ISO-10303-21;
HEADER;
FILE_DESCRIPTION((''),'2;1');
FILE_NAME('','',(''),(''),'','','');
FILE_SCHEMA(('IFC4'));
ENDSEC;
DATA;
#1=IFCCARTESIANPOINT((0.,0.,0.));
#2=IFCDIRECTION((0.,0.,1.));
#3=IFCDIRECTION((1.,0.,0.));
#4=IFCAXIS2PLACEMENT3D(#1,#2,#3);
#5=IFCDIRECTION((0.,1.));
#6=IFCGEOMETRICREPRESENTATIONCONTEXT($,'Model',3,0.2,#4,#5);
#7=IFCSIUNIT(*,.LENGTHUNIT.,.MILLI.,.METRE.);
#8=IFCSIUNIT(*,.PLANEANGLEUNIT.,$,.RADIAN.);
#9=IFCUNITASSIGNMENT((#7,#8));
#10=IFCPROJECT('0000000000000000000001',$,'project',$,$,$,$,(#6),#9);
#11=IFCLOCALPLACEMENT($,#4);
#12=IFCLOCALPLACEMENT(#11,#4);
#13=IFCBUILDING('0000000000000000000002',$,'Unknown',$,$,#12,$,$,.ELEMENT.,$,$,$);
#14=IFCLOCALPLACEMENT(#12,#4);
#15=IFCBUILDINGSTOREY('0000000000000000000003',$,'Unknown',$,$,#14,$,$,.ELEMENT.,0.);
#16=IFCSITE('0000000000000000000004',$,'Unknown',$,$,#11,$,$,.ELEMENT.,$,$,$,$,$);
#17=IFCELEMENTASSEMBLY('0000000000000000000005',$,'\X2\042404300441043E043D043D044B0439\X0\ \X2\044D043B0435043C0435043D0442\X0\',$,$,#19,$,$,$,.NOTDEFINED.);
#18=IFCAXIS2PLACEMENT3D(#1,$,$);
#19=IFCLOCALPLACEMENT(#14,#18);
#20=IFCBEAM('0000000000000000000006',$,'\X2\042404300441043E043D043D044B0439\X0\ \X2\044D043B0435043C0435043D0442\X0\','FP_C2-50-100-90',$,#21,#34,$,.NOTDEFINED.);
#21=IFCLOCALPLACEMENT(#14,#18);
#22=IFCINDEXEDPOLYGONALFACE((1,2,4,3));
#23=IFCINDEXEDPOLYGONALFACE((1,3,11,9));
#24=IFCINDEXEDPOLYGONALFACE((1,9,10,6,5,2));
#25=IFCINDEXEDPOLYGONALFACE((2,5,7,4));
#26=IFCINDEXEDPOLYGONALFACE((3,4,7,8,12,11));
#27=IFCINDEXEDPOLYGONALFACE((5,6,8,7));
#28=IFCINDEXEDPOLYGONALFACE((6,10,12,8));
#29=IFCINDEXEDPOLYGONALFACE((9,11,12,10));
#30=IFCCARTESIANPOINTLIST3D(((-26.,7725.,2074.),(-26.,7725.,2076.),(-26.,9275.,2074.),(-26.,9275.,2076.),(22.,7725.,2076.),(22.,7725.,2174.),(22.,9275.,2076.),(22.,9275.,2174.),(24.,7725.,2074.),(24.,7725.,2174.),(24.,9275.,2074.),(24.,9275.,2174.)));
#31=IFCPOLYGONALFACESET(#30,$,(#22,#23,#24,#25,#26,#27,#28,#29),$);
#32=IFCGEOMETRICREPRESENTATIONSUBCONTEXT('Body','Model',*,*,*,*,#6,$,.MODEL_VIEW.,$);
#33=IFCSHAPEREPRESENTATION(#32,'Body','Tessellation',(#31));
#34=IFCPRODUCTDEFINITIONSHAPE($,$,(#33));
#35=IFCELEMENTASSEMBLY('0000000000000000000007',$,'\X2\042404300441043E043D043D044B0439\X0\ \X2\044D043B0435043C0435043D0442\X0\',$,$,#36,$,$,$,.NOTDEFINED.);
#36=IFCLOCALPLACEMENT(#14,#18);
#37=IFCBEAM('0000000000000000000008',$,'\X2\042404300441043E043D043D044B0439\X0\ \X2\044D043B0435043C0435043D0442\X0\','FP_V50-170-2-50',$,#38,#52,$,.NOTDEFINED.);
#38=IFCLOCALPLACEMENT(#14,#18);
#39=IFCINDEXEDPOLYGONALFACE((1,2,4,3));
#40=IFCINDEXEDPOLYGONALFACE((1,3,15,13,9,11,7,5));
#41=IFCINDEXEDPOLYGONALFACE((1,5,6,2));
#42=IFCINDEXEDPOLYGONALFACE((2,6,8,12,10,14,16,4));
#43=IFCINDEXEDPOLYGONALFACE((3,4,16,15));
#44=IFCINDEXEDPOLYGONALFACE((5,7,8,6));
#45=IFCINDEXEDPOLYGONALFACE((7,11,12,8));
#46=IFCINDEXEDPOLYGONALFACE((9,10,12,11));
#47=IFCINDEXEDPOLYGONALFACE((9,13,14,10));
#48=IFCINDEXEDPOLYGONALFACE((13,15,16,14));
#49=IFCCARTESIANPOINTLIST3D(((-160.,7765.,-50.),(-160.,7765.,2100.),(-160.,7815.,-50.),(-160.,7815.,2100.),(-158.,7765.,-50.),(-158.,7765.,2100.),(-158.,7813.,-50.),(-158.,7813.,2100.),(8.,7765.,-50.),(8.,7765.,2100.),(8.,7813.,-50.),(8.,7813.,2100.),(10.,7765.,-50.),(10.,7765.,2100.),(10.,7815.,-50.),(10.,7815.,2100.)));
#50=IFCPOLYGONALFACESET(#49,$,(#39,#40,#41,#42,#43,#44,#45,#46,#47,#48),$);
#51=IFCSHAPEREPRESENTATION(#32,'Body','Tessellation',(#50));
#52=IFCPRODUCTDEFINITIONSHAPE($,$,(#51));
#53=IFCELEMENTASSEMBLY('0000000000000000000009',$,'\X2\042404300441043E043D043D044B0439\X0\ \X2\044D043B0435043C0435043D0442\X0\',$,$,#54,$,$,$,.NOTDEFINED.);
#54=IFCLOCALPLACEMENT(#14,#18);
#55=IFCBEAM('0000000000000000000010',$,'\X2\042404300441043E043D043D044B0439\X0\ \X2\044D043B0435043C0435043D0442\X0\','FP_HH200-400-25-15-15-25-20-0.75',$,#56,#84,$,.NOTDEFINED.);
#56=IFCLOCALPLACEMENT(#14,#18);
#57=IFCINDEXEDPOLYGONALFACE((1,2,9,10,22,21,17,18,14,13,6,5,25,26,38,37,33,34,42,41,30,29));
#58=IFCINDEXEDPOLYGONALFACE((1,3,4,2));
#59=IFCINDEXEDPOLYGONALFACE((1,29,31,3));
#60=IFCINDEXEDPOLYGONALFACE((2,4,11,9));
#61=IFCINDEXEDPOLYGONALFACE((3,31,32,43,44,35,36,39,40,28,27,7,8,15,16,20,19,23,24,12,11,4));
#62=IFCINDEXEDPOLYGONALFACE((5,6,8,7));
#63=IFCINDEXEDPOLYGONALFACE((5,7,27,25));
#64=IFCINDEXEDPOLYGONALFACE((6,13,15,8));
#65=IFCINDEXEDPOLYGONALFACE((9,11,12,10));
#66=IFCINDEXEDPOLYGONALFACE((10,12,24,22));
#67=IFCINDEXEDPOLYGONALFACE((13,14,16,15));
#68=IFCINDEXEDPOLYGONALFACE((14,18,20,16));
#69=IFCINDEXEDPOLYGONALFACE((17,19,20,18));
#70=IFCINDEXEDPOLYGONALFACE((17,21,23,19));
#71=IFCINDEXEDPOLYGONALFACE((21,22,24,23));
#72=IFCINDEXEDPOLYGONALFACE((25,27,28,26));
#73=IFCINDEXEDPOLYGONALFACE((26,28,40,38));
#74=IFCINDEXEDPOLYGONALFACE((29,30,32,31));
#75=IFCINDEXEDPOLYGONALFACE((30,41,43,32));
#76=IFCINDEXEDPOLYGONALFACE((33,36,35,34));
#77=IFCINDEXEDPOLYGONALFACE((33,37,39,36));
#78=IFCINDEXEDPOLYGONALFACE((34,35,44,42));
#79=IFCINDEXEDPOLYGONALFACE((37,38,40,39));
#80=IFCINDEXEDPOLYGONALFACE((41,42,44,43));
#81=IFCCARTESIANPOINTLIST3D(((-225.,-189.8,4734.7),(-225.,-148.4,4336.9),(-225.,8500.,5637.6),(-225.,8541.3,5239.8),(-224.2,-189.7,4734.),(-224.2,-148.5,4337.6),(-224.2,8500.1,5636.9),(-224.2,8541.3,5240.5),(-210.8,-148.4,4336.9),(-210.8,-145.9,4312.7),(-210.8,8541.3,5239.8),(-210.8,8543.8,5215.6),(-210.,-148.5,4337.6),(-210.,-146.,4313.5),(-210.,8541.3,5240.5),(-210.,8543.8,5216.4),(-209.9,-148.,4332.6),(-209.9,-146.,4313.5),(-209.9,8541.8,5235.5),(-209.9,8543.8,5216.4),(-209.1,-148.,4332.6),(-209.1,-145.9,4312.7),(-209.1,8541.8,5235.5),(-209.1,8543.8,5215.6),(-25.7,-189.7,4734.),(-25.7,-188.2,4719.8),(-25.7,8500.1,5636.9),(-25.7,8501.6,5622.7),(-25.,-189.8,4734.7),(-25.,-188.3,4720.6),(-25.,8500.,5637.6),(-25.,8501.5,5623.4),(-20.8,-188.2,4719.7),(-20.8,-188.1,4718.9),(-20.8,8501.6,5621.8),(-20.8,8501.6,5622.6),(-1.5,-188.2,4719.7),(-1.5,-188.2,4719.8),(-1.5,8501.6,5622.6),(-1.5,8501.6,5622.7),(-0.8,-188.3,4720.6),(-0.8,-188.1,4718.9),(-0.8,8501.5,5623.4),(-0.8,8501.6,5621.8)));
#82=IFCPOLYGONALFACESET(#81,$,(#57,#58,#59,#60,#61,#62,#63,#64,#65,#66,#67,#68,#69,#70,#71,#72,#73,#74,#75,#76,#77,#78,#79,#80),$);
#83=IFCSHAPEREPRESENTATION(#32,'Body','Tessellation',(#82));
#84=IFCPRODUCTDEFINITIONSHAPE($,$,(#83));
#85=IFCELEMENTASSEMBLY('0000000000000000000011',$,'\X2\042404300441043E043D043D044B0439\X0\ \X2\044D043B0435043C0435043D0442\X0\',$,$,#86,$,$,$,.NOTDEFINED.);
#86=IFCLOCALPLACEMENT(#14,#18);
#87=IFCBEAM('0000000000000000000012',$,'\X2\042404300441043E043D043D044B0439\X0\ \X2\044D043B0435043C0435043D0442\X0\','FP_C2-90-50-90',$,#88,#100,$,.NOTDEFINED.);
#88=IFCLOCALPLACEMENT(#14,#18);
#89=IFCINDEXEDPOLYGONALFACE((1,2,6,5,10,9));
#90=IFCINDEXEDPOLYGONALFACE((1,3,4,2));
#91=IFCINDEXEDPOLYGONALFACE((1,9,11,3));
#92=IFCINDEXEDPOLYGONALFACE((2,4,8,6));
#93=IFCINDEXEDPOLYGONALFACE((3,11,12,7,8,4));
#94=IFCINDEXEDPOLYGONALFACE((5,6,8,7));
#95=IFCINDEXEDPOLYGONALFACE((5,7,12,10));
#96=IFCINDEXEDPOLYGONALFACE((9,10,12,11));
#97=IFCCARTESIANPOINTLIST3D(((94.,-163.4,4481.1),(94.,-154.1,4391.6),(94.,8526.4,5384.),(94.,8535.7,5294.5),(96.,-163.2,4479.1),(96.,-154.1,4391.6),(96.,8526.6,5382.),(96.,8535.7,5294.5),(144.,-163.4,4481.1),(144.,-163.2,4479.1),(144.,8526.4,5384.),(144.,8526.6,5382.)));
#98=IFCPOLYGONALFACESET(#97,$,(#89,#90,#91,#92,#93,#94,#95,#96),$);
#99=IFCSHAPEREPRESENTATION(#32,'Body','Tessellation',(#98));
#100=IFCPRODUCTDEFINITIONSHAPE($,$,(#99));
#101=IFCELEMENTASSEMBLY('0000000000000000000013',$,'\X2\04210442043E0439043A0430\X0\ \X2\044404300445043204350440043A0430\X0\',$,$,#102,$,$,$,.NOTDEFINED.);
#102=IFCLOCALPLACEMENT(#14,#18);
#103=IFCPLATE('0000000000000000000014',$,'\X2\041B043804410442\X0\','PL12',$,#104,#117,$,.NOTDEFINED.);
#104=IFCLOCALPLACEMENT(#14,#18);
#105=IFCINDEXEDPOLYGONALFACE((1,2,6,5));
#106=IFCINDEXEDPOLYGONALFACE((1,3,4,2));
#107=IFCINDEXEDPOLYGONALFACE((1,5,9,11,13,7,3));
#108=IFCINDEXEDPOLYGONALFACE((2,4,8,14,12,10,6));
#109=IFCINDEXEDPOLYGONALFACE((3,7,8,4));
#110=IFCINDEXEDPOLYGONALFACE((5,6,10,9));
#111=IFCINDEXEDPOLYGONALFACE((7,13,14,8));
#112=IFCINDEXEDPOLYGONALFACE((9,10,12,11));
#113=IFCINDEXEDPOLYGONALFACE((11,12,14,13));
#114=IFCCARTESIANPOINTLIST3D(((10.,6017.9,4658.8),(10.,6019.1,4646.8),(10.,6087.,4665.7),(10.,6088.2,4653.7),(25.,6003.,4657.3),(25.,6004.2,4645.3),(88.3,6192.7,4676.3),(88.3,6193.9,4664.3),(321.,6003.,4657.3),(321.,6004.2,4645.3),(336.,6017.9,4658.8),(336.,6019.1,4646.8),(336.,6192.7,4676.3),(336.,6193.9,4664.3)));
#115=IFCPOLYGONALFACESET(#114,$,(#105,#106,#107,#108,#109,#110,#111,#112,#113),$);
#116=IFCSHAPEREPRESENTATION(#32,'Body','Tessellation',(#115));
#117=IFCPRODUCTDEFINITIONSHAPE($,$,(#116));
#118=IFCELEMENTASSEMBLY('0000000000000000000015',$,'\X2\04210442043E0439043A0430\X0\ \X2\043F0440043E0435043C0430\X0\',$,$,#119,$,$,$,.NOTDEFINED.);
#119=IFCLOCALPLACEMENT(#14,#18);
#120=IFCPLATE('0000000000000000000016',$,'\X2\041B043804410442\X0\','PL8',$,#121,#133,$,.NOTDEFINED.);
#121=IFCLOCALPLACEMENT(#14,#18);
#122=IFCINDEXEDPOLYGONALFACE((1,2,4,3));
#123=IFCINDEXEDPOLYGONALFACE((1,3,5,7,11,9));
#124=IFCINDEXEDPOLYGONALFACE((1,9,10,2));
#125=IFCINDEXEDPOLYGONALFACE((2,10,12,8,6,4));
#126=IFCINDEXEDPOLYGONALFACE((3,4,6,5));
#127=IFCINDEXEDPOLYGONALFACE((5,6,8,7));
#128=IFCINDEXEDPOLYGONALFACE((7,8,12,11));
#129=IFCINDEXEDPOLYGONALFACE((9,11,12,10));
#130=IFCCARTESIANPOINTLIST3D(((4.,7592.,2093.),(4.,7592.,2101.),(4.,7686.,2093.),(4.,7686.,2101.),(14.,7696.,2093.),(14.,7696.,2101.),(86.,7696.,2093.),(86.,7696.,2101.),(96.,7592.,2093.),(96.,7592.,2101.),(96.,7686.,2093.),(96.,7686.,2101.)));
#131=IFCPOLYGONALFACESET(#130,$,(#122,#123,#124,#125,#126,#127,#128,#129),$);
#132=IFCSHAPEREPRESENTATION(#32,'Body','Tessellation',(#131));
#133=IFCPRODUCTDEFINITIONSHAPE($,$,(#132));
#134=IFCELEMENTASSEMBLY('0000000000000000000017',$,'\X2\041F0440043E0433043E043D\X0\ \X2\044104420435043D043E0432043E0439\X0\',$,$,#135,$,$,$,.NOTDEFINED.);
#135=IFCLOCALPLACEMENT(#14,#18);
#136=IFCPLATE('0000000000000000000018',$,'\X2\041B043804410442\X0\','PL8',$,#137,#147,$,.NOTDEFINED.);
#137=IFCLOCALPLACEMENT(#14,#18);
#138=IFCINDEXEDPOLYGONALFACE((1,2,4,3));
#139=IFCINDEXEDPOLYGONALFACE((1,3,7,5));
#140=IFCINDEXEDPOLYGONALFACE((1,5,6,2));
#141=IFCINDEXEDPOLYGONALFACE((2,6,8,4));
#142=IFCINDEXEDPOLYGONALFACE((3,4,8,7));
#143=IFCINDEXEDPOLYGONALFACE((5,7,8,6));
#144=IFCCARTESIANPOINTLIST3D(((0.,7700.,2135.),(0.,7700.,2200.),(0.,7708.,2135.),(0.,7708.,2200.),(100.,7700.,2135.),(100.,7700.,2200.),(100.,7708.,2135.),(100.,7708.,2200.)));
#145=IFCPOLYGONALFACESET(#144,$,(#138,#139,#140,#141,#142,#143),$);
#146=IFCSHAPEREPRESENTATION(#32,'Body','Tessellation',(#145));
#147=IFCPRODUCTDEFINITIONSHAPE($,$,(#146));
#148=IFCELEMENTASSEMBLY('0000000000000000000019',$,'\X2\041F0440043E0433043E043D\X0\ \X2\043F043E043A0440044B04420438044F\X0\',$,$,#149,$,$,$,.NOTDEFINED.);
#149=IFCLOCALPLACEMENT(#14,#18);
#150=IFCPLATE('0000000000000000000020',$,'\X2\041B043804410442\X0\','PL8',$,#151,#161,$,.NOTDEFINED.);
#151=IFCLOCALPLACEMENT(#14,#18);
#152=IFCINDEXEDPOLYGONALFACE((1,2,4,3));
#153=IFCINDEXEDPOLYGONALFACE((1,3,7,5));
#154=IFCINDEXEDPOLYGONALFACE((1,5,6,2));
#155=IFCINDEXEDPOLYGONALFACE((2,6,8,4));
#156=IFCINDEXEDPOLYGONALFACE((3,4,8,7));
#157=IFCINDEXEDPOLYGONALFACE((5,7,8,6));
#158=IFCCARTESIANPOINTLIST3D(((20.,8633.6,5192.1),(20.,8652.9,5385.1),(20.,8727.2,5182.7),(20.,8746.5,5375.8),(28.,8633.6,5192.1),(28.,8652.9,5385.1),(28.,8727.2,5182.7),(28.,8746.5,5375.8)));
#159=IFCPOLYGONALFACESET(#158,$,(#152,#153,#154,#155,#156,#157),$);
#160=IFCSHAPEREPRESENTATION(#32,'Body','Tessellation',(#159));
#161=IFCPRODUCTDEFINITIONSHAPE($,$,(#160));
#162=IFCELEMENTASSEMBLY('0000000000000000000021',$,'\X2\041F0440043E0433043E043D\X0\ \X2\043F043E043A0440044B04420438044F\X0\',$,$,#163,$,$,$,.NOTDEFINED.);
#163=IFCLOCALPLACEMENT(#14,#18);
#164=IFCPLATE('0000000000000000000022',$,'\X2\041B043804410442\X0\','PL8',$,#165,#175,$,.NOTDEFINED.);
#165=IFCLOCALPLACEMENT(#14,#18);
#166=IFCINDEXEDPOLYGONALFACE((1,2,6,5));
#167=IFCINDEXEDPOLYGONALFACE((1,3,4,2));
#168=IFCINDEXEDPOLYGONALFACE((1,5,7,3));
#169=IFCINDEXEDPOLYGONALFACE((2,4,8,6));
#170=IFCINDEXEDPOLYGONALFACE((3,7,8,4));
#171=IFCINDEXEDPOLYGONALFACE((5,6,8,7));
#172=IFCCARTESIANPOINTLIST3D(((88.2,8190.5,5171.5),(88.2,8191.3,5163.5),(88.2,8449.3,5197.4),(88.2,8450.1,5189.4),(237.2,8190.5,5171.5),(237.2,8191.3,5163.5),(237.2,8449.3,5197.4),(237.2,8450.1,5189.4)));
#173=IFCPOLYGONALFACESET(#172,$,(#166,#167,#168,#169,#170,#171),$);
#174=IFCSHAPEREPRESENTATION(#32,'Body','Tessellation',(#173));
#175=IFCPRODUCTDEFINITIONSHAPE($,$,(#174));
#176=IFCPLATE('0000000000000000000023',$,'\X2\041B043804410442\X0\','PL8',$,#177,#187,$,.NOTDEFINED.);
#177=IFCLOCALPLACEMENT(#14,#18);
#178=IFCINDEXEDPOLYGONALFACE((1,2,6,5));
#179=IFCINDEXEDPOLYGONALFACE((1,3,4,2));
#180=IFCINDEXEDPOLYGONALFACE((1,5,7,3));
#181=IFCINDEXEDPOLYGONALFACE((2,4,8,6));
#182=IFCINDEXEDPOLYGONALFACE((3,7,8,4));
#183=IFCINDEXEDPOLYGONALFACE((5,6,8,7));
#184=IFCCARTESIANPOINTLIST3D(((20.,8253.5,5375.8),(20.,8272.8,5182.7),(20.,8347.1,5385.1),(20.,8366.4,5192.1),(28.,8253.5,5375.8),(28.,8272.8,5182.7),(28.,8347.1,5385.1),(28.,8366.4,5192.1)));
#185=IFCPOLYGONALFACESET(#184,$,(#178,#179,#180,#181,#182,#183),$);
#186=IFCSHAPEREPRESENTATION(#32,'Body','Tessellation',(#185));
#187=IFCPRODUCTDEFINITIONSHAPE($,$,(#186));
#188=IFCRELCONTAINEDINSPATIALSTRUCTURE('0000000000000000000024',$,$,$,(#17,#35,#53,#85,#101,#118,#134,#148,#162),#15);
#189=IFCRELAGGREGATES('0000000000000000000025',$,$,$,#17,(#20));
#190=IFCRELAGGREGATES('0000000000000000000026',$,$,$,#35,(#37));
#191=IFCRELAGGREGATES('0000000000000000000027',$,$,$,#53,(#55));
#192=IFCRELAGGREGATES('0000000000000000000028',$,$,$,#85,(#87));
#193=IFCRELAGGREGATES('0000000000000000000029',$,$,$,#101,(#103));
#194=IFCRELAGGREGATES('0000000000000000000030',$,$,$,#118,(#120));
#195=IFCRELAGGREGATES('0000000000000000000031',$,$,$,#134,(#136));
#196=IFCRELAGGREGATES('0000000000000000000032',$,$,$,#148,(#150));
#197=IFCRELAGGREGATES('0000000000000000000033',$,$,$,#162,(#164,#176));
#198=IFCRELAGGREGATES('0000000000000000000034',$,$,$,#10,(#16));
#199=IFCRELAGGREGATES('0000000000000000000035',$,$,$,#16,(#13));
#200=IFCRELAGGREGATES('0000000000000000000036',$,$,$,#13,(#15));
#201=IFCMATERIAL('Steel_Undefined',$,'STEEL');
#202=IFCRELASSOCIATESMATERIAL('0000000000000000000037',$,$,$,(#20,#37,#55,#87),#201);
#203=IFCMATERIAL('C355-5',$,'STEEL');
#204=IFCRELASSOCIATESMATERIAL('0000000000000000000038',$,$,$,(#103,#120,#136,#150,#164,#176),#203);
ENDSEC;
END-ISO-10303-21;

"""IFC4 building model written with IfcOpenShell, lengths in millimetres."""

from ifc_helpers import new_model, si_unit, direction, frame, origin_with_axes, place, context, subcontext, project, spatial, line, indexed_curve, outline, extrude, material, element, aggregate, save


model = new_model("IFC4")

# Units and contexts
model_context = context("Model", 3, precision=0.2, world=origin_with_axes(), true_north=direction((0.0, 1.0)))
body_context = subcontext(model_context, "Body", "Model", "MODEL_VIEW")
ifc_project = project(units=[si_unit("LENGTHUNIT", "METRE", prefix="MILLI"), si_unit("PLANEANGLEUNIT", "RADIAN")], contexts=[model_context])

# Site, building, storey
site_placement = place(None, origin_with_axes())
site = spatial("IfcSite", under=ifc_project, at=site_placement, Name="Unknown", CompositionType="ELEMENT")
building_placement = place(site_placement, origin_with_axes())
building = spatial("IfcBuilding", under=site, at=building_placement, Name="Unknown", CompositionType="ELEMENT")
storey_placement = place(building_placement, origin_with_axes())
storey = spatial("IfcBuildingStorey", under=building, at=storey_placement, Name="Unknown", CompositionType="ELEMENT", Elevation=0.0)

# Element assemblies, beams
ifc_material_1 = material(Name="Steel_Undefined", Category="STEEL")
assembly_1_placement = place(storey_placement, frame((-1.0, 7725.0, 2075.0), z_axis=(1.0, 0.0, 0.0), x_axis=(0.0, 1.0, 0.0)))
assembly_1 = element("IfcElementAssembly", 1, at=assembly_1_placement, inside=storey, Name="Фасонный элемент", PredefinedType="NOTDEFINED")
beam_1_placement = place(assembly_1_placement, origin_with_axes())
beam_1 = element("IfcBeam", 2, at=beam_1_placement, material=ifc_material_1, Name="Фасонный элемент", Description="FP_C2-50-100-90", PredefinedType="NOTDEFINED", context=body_context, shape_type="SolidModel", body=[
    extrude(outline(indexed_curve([(-25.0, -1.0), (25.0, -1.0), (25.0, 99.0), (23.0, 99.0), (23.0, 1.0), (-25.0, 1.0)], segments=[line(1, 2, 3, 4, 5, 6, 1)])), frame((0.0, 0.0, 0.0), z_axis=(-1.0, 0.0, 0.0), x_axis=(0.0, 0.0, 1.0)), (0.0, 0.0, -1.0), 1550.0),
])
aggregate(assembly_1, [beam_1])
assembly_2_placement = place(storey_placement, frame((-75.0, 7790.0, 2100.0), z_axis=(1.0, 0.0, 0.0), x_axis=(0.0, 0.0, -1.0)))
assembly_2 = element("IfcElementAssembly", 3, at=assembly_2_placement, inside=storey, Name="Фасонный элемент", PredefinedType="NOTDEFINED")
beam_2_placement = place(assembly_2_placement, origin_with_axes())
beam_2 = element("IfcBeam", 4, at=beam_2_placement, material=ifc_material_1, Name="Фасонный элемент", Description="FP_V50-170-2-50", PredefinedType="NOTDEFINED", context=body_context, shape_type="SolidModel", body=[
    extrude(outline(indexed_curve([(-85.0, -25.0), (-83.0, -25.0), (-83.0, 23.0), (83.0, 23.0), (83.0, -25.0), (85.0, -25.0), (85.0, 25.0), (-85.0, 25.0)], segments=[line(1, 2, 3, 4, 5, 6, 7, 8, 1)])), frame((0.0, 0.0, 0.0), z_axis=(-1.0, 0.0, 0.0), x_axis=(0.0, 0.0, 1.0)), (0.0, 0.0, -1.0), 2150.0),
])
aggregate(assembly_2, [beam_2])
assembly_3_placement = place(storey_placement, frame((-125.0, 8520.7, 5438.7), z_axis=(0.0, -0.103345, 0.994646), x_axis=(0.0, -0.994646, -0.103345)))
assembly_3 = element("IfcElementAssembly", 5, at=assembly_3_placement, inside=storey, Name="Фасонный элемент", PredefinedType="NOTDEFINED")
beam_3_placement = place(assembly_3_placement, origin_with_axes())
beam_3 = element("IfcBeam", 6, at=beam_3_placement, material=ifc_material_1, Name="Фасонный элемент", Description="FP_HH200-400-25-15-15-25-20-0.75", PredefinedType="NOTDEFINED", context=body_context, shape_type="SolidModel", body=[
    extrude(outline(indexed_curve([(-200.0, -100.0), (200.0, -100.0), (200.0, 100.0), (185.8, 100.0), (185.8, 124.2), (184.1, 124.2), (184.1, 104.2), (184.9, 104.2), (184.9, 123.5), (185.0, 123.5), (185.0, 99.2), (199.2, 99.2), (199.2, -99.2), (-199.2, -99.2), (-199.2, -85.0), (-223.5, -85.0), (-223.5, -84.9), (-204.2, -84.9), (-204.2, -84.1), (-224.2, -84.1), (-224.2, -85.8), (-200.0, -85.8)], segments=[line(1, 2, 3, 4, 5, 6, 7, 8, 9, 10, 11, 12, 13, 14, 15, 16, 17, 18, 19, 20, 21, 22, 1)])), frame((0.0, 0.0, 0.0), z_axis=(-1.0, 0.0, 0.0), x_axis=(0.0, 0.0, 1.0)), (0.0, 0.0, -1.0), 8736.6),
])
aggregate(assembly_3, [beam_3])
assembly_4_placement = place(storey_placement, frame((95.0, 8531.0, 5339.2), z_axis=(0.0, -0.103345, 0.994646), x_axis=(0.0, -0.994646, -0.103345)))
assembly_4 = element("IfcElementAssembly", 7, at=assembly_4_placement, inside=storey, Name="Фасонный элемент", PredefinedType="NOTDEFINED")
beam_4_placement = place(assembly_4_placement, origin_with_axes())
beam_4 = element("IfcBeam", 8, at=beam_4_placement, material=ifc_material_1, Name="Фасонный элемент", Description="FP_C2-90-50-90", PredefinedType="NOTDEFINED", context=body_context, shape_type="SolidModel", body=[
    extrude(outline(indexed_curve([(-45.0, -1.0), (45.0, -1.0), (45.0, 49.0), (43.0, 49.0), (43.0, 1.0), (-45.0, 1.0)], segments=[line(1, 2, 3, 4, 5, 6, 1)])), frame((0.0, 0.0, 0.0), z_axis=(-1.0, 0.0, 0.0), x_axis=(0.0, 0.0, 1.0)), (0.0, 0.0, -1.0), 8736.6),
])
aggregate(assembly_4, [beam_4])

# Element assembly, plate
assembly_5_placement = place(storey_placement, frame((173.0, 6000.0, -200.0), z_axis=(0.0, -1.0, 0.0), x_axis=(0.0, 0.0, 1.0)))
assembly_5 = element("IfcElementAssembly", 9, at=assembly_5_placement, inside=storey, Name="Стойка фахверка", PredefinedType="NOTDEFINED")
ifc_material_2 = material(Name="C355-5", Category="STEEL")
plate_1_placement = place(assembly_5_placement, frame((4870.3, 163.0, -193.3), z_axis=(-0.995037, 0.0, -0.099504), x_axis=(0.0, -1.0, 0.0)))
plate_1 = element("IfcPlate", 10, at=plate_1_placement, material=ifc_material_2, Name="Лист", Description="PL12", PredefinedType="NOTDEFINED", context=body_context, shape_type="SolidModel", body=[
    extrude(outline(indexed_curve([(0.0, 106.2), (78.2, 0.0), (326.0, 0.0), (326.0, 175.6), (311.0, 190.6), (15.0, 190.6), (0.0, 175.6)], segments=[line(1, 2, 3, 4, 5, 6, 7, 1)])), frame((0.0, 0.0, 6.0), z_axis=(0.0, 0.0, 1.0), x_axis=(1.0, 0.0, 0.0)), (0.0, 0.0, -1.0), 12.0),
])
aggregate(assembly_5, [plate_1])

# Element assembly, plate
assembly_6_placement = place(storey_placement, frame((50.0, 7650.0, -50.0), z_axis=(0.0, -1.0, 0.0), x_axis=(0.0, 0.0, 1.0)))
assembly_6 = element("IfcElementAssembly", 11, at=assembly_6_placement, inside=storey, Name="Стойка проема", PredefinedType="NOTDEFINED")
plate_2_placement = place(assembly_6_placement, frame((2147.0, -46.0, -46.0), z_axis=(1.0, 0.0, 0.0), x_axis=(0.0, 1.0, 0.0)))
plate_2 = element("IfcPlate", 12, at=plate_2_placement, material=ifc_material_2, Name="Лист", Description="PL8", PredefinedType="NOTDEFINED", context=body_context, shape_type="SolidModel", body=[
    extrude(outline(indexed_curve([(0.0, 10.0), (10.0, 0.0), (82.0, 0.0), (92.0, 10.0), (92.0, 104.0), (0.0, 104.0)], segments=[line(1, 2, 3, 4, 5, 6, 1)])), frame((0.0, 0.0, 4.0), z_axis=(0.0, 0.0, 1.0), x_axis=(1.0, 0.0, 0.0)), (0.0, 0.0, -1.0), 8.0),
])
aggregate(assembly_6, [plate_2])

# Element assembly, plate
assembly_7_placement = place(storey_placement, frame((50.0, 11000.0, 2250.0), z_axis=(0.0, 0.0, -1.0), x_axis=(0.0, -1.0, 0.0)))
assembly_7 = element("IfcElementAssembly", 13, at=assembly_7_placement, inside=storey, Name="Прогон стеновой", PredefinedType="NOTDEFINED")
plate_3_placement = place(assembly_7_placement, frame((3296.0, -50.0, 50.0), z_axis=(-1.0, 0.0, 0.0), x_axis=(0.0, 0.0, 1.0)))
plate_3 = element("IfcPlate", 14, at=plate_3_placement, material=ifc_material_2, Name="Лист", Description="PL8", PredefinedType="NOTDEFINED", context=body_context, shape_type="SolidModel", body=[
    extrude(outline(indexed_curve([(0.0, 0.0), (65.0, 0.0), (65.0, 100.0), (0.0, 100.0)], segments=[line(1, 2, 3, 4, 1)])), frame((0.0, 0.0, 4.0), z_axis=(0.0, 0.0, 1.0), x_axis=(1.0, 0.0, 0.0)), (0.0, 0.0, -1.0), 8.0),
])
aggregate(assembly_7, [plate_3])

# Element assembly, plate
assembly_8_placement = place(storey_placement, frame((6000.0, 8690.0, 5283.9), z_axis=(0.0, -0.995037, 0.099504), x_axis=(-1.0, 0.0, 0.0)))
assembly_8 = element("IfcElementAssembly", 15, at=assembly_8_placement, inside=storey, Name="Прогон покрытия", PredefinedType="NOTDEFINED")
plate_4_placement = place(assembly_8_placement, frame((5976.0, -97.0, 47.0), z_axis=(1.0, 0.0, 0.0), x_axis=(0.0, 0.0, -1.0)))
plate_4 = element("IfcPlate", 16, at=plate_4_placement, material=ifc_material_2, Name="Лист", Description="PL8", PredefinedType="NOTDEFINED", context=body_context, shape_type="SolidModel", body=[
    extrude(outline(indexed_curve([(0.0, 0.0), (94.0, 0.0), (94.0, 194.0), (0.0, 194.0)], segments=[line(1, 2, 3, 4, 1)])), frame((0.0, 0.0, 4.0), z_axis=(0.0, 0.0, 1.0), x_axis=(1.0, 0.0, 0.0)), (0.0, 0.0, -1.0), 8.0),
])
aggregate(assembly_8, [plate_4])

# Element assembly, plates
assembly_9_placement = place(storey_placement, frame((0.0, 8310.0, 5283.9), z_axis=(0.0, 0.995037, 0.099504), x_axis=(1.0, 0.0, 0.0)))
assembly_9 = element("IfcElementAssembly", 17, at=assembly_9_placement, inside=storey, Name="Прогон покрытия", PredefinedType="NOTDEFINED")
plate_5_placement = place(assembly_9_placement, frame((88.2, 104.0, -130.0), z_axis=(0.0, 1.0, 0.0), x_axis=(0.0, 0.0, 1.0)))
plate_5 = element("IfcPlate", 18, at=plate_5_placement, material=ifc_material_2, Name="Лист", Description="PL8", PredefinedType="NOTDEFINED", context=body_context, shape_type="SolidModel", body=[
    extrude(outline(indexed_curve([(0.0, 0.0), (260.0, 0.0), (260.0, 149.0), (0.0, 149.0)], segments=[line(1, 2, 3, 4, 1)])), frame((0.0, 0.0, 4.0), z_axis=(0.0, 0.0, 1.0), x_axis=(1.0, 0.0, 0.0)), (0.0, 0.0, -1.0), 8.0),
])
plate_6_placement = place(assembly_9_placement, frame((24.0, 97.0, 47.0), z_axis=(-1.0, 0.0, 0.0), x_axis=(0.0, 0.0, -1.0)))
plate_6 = element("IfcPlate", 19, at=plate_6_placement, material=ifc_material_2, Name="Лист", Description="PL8", PredefinedType="NOTDEFINED", context=body_context, shape_type="SolidModel", body=[
    extrude(outline(indexed_curve([(0.0, 0.0), (94.0, 0.0), (94.0, 194.0), (0.0, 194.0)], segments=[line(1, 2, 3, 4, 1)])), frame((0.0, 0.0, 4.0), z_axis=(0.0, 0.0, 1.0), x_axis=(1.0, 0.0, 0.0)), (0.0, 0.0, -1.0), 8.0),
])
aggregate(assembly_9, [plate_5, plate_6])

save(model, "model.ifc")
